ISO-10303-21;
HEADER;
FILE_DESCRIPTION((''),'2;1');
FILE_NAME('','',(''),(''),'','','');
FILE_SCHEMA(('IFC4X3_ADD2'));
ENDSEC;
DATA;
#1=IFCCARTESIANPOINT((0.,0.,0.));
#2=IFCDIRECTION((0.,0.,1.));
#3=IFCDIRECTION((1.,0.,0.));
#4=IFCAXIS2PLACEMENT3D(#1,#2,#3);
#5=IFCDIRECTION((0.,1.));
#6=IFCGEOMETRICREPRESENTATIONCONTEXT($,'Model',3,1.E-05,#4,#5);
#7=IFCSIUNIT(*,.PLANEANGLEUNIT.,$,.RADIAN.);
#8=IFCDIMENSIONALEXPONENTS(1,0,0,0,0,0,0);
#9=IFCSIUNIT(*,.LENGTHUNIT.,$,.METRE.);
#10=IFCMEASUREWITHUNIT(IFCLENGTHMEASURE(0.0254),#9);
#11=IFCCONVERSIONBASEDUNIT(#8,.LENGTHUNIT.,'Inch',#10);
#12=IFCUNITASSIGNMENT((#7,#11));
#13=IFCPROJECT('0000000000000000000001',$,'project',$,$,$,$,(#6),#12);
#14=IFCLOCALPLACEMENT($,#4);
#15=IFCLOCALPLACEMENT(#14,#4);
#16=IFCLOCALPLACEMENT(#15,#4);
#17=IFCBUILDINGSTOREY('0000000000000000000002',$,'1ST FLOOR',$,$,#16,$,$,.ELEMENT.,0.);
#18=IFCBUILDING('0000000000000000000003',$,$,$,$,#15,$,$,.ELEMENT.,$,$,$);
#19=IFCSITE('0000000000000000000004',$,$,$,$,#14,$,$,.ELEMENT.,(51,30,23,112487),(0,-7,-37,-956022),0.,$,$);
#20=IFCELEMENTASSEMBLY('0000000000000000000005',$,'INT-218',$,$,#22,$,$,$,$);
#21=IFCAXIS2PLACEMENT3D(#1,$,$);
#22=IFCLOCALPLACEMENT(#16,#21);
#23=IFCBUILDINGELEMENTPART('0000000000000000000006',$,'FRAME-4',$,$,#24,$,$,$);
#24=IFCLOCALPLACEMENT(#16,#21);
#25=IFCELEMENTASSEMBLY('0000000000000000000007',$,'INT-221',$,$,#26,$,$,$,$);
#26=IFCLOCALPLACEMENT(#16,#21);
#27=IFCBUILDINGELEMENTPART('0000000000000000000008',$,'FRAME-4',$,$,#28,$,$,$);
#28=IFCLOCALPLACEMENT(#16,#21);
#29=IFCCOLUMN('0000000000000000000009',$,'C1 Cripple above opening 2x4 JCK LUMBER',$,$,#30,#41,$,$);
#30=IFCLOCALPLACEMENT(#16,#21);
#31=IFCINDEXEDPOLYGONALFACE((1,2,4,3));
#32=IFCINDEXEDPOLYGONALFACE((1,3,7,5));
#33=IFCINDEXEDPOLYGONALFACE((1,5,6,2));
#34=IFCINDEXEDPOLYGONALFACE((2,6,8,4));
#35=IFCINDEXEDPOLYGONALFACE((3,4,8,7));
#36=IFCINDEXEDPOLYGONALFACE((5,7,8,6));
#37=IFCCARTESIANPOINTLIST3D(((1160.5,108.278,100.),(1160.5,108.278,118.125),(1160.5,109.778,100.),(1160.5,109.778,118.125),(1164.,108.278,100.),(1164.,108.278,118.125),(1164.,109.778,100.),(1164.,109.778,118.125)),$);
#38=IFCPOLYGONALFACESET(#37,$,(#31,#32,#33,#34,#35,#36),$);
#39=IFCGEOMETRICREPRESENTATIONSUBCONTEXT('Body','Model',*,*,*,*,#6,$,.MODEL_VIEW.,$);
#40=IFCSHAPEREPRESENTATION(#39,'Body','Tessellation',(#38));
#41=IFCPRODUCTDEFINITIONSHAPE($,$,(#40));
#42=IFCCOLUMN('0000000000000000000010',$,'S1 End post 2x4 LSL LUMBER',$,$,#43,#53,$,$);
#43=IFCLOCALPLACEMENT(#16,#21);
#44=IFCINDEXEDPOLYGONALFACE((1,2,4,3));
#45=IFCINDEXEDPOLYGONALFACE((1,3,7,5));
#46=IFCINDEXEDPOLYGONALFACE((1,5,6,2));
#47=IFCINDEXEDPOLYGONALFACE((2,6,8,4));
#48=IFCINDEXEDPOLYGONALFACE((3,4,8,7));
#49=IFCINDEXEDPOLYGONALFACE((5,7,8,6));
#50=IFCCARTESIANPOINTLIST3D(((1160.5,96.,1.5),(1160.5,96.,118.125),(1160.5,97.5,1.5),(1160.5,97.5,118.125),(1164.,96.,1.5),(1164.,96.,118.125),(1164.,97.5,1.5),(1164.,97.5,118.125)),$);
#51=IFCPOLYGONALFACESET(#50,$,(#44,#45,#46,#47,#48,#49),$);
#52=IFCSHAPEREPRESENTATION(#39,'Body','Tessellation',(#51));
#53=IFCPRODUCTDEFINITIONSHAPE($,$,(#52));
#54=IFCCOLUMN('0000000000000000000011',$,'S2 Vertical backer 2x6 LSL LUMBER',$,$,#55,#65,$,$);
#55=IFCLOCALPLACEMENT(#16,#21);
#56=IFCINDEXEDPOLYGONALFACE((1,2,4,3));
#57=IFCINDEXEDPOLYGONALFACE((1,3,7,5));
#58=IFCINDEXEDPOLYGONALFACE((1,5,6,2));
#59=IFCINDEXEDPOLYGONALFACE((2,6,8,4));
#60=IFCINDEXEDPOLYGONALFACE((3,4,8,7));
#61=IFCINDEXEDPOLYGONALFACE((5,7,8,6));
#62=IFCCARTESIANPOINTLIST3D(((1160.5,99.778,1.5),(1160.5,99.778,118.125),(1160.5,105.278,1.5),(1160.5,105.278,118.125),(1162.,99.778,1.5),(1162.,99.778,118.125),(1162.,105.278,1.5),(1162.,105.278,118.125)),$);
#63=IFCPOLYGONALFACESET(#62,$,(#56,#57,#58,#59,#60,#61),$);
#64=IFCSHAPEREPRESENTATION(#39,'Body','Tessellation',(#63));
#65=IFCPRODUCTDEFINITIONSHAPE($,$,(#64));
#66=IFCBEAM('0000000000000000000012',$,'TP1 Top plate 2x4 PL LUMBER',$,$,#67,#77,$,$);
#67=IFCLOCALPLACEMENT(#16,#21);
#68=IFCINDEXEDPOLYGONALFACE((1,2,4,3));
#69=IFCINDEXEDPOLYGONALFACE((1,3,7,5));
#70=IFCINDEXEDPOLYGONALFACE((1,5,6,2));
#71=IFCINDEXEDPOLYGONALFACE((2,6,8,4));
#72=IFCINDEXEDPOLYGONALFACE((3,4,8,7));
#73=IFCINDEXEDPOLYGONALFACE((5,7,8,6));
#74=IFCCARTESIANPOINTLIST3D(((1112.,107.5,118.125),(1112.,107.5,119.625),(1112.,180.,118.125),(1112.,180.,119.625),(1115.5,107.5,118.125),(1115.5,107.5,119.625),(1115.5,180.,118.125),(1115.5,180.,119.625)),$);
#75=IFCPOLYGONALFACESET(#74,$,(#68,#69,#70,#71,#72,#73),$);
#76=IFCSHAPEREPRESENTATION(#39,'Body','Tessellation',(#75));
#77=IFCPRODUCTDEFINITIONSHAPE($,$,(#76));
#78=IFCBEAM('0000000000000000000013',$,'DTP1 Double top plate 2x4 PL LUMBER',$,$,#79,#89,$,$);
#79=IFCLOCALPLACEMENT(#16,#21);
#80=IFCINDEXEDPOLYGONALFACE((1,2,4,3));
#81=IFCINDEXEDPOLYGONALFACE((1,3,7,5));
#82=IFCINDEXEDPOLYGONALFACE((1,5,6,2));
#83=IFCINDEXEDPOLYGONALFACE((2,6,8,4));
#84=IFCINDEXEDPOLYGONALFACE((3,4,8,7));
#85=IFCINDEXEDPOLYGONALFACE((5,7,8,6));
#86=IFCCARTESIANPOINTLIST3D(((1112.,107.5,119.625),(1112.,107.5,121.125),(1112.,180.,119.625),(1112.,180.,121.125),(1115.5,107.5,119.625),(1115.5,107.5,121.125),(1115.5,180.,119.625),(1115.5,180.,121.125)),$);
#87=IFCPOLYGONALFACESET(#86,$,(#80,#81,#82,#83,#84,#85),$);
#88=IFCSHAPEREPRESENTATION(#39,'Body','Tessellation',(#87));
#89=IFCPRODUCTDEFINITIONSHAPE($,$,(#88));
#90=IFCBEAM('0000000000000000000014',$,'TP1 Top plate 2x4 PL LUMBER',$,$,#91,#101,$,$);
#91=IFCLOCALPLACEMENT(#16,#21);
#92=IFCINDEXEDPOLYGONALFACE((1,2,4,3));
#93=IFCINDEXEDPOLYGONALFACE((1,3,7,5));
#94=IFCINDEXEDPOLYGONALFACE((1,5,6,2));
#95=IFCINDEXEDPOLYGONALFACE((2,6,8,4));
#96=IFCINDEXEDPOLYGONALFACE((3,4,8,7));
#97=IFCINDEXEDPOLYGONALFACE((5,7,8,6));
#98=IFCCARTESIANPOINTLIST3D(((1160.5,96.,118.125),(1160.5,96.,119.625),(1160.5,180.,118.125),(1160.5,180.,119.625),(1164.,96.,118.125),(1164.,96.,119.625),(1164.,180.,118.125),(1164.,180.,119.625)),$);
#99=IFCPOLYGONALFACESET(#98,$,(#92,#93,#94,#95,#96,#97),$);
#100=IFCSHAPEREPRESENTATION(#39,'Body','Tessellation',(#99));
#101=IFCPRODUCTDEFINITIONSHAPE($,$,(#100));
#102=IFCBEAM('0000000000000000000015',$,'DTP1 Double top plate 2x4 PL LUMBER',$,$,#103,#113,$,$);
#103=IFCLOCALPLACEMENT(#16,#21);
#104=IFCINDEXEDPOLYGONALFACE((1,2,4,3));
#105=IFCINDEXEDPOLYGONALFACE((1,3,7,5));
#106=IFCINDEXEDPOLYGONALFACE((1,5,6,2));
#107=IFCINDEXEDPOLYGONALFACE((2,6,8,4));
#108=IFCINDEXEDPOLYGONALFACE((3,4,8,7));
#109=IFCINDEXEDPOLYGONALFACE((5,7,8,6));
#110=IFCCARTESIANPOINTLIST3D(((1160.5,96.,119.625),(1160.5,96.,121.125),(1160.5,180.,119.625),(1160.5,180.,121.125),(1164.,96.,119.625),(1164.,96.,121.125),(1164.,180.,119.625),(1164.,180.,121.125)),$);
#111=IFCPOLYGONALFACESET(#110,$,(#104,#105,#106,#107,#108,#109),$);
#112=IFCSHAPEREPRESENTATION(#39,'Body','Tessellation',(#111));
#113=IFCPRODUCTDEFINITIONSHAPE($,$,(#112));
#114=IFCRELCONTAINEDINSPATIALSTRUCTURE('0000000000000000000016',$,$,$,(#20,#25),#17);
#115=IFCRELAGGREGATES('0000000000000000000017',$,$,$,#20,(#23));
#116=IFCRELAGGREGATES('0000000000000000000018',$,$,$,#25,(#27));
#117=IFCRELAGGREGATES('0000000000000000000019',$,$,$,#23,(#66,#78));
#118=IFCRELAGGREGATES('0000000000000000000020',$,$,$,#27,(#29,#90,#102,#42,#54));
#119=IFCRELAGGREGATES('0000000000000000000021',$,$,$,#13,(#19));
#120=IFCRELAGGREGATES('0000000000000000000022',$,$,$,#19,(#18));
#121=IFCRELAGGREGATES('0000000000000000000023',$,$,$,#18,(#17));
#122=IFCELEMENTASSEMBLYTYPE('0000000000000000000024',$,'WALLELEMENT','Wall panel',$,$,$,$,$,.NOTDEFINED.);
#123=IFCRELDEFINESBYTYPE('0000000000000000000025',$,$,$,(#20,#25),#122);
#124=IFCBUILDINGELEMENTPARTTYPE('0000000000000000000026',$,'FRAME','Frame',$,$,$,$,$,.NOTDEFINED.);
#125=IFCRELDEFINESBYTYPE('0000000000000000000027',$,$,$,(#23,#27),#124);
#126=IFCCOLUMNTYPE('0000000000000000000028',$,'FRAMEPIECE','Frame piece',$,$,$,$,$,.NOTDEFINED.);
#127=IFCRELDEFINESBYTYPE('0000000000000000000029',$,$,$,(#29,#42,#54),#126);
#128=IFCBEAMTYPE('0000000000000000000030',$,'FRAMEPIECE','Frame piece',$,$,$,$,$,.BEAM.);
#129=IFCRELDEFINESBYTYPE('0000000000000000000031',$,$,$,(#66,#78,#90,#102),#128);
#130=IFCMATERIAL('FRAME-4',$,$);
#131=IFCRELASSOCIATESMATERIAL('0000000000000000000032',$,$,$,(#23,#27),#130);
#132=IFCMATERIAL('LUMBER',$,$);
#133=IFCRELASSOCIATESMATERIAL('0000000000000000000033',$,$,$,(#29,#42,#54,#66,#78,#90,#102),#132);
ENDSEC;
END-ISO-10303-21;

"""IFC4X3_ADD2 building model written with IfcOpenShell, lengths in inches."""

from ifc_helpers import new_model, entity, si_unit, converted_unit, direction, frame, origin_with_axes, origin_2d_with_axis, place, context, subcontext, project, spatial, rectangle, extrude, material, type_object, element, aggregate, save


model = new_model("IFC4X3_ADD2")

# Units and contexts
model_context = context("Model", 3, precision=1e-05, world=origin_with_axes(), true_north=direction((0.0, 1.0)))
body_context = subcontext(model_context, "Body", "Model", "MODEL_VIEW")
ifc_project = project(units=[si_unit("PLANEANGLEUNIT", "RADIAN"), converted_unit("LENGTHUNIT", "Inch", entity("IfcLengthMeasure", 0.0254), si_unit("LENGTHUNIT", "METRE"), dimensions=[1, 0, 0, 0, 0, 0, 0])], contexts=[model_context])

# Site, building, storey
site_placement = place(None, origin_with_axes())
site = spatial("IfcSite", under=ifc_project, at=site_placement, CompositionType="ELEMENT", RefLatitude=(51, 30, 23, 112487), RefLongitude=(0, -7, -37, -956022), RefElevation=0.0)
building_placement = place(site_placement, origin_with_axes())
building = spatial("IfcBuilding", under=site, at=building_placement, CompositionType="ELEMENT")
storey_placement = place(building_placement, origin_with_axes())
storey = spatial("IfcBuildingStorey", under=building, at=storey_placement, Name="1ST FLOOR", CompositionType="ELEMENT", Elevation=0.0)

# Element assemblies, building element parts, columns
element_assembly_type = type_object("IfcElementAssemblyType", Name="WALLELEMENT", Description="Wall panel", PredefinedType="NOTDEFINED")
building_element_part_type = type_object("IfcBuildingElementPartType", Name="FRAME", Description="Frame", PredefinedType="NOTDEFINED")
ifc_material_1 = material(Name="LUMBER")
column_type = type_object("IfcColumnType", Name="FRAMEPIECE", Description="Frame piece", PredefinedType="NOTDEFINED")
assembly_1_placement = place(storey_placement, origin_with_axes())
assembly_1 = element("IfcElementAssembly", 1, at=assembly_1_placement, inside=storey, type_object=element_assembly_type, Name="INT-218")
ifc_material_2 = material(Name="FRAME-4")
building_element_part_1_placement = place(storey_placement, origin_with_axes())
building_element_part_1 = element("IfcBuildingElementPart", 2, at=building_element_part_1_placement, type_object=building_element_part_type, material=ifc_material_2, Name="FRAME-4")
aggregate(assembly_1, [building_element_part_1])
assembly_2_placement = place(storey_placement, origin_with_axes())
assembly_2 = element("IfcElementAssembly", 3, at=assembly_2_placement, inside=storey, type_object=element_assembly_type, Name="INT-221")
building_element_part_2_placement = place(storey_placement, origin_with_axes())
building_element_part_2 = element("IfcBuildingElementPart", 4, at=building_element_part_2_placement, type_object=building_element_part_type, material=ifc_material_2, Name="FRAME-4")
aggregate(assembly_2, [building_element_part_2])
column_1_placement = place(storey_placement, frame((1162.25, 109.028, 118.125), z_axis=(0.0, 0.0, -1.0), x_axis=(0.0, 1.0, 0.0)))
column_1 = element("IfcColumn", 5, at=column_1_placement, type_object=column_type, material=ifc_material_1, Name="C1 Cripple above opening 2x4 JCK LUMBER", context=body_context, shape_type="SweptSolid", body=[
    extrude(rectangle(XDim=1.5, YDim=3.5, at=origin_2d_with_axis()), origin_with_axes(), (0.0, 0.0, 1.0), 18.125),
])
column_2_placement = place(storey_placement, frame((1162.25, 96.75, 118.125), z_axis=(0.0, 0.0, -1.0), x_axis=(0.0, 1.0, 0.0)))
column_2 = element("IfcColumn", 6, at=column_2_placement, type_object=column_type, material=ifc_material_1, Name="S1 End post 2x4 LSL LUMBER", context=body_context, shape_type="SweptSolid", body=[
    extrude(rectangle(XDim=1.5, YDim=3.5, at=origin_2d_with_axis()), origin_with_axes(), (0.0, 0.0, 1.0), 116.625),
])
column_3_placement = place(storey_placement, frame((1161.25, 102.528, 118.125), z_axis=(0.0, 0.0, -1.0), x_axis=(1.0, 0.0, 0.0)))
column_3 = element("IfcColumn", 7, at=column_3_placement, type_object=column_type, material=ifc_material_1, Name="S2 Vertical backer 2x6 LSL LUMBER", context=body_context, shape_type="SweptSolid", body=[
    extrude(rectangle(XDim=1.5, YDim=5.5, at=origin_2d_with_axis()), origin_with_axes(), (0.0, 0.0, 1.0), 116.625),
])

# Beams
beam_type = type_object("IfcBeamType", Name="FRAMEPIECE", Description="Frame piece", PredefinedType="BEAM")
beam_1_placement = place(storey_placement, frame((1113.75, 107.5, 118.875), z_axis=(0.0, 1.0, 0.0), x_axis=(0.0, 0.0, -1.0)))
beam_1 = element("IfcBeam", 8, at=beam_1_placement, type_object=beam_type, material=ifc_material_1, Name="TP1 Top plate 2x4 PL LUMBER", context=body_context, shape_type="SweptSolid", body=[
    extrude(rectangle(XDim=1.5, YDim=3.5, at=origin_2d_with_axis()), origin_with_axes(), (0.0, 0.0, 1.0), 72.5),
])
beam_2_placement = place(storey_placement, frame((1113.75, 107.5, 120.375), z_axis=(0.0, 1.0, 0.0), x_axis=(0.0, 0.0, -1.0)))
beam_2 = element("IfcBeam", 9, at=beam_2_placement, type_object=beam_type, material=ifc_material_1, Name="DTP1 Double top plate 2x4 PL LUMBER", context=body_context, shape_type="SweptSolid", body=[
    extrude(rectangle(XDim=1.5, YDim=3.5, at=origin_2d_with_axis()), origin_with_axes(), (0.0, 0.0, 1.0), 72.5),
])
aggregate(building_element_part_1, [beam_1, beam_2])
beam_3_placement = place(storey_placement, frame((1162.25, 180.0, 118.875), z_axis=(0.0, -1.0, 0.0), x_axis=(0.0, 0.0, -1.0)))
beam_3 = element("IfcBeam", 10, at=beam_3_placement, type_object=beam_type, material=ifc_material_1, Name="TP1 Top plate 2x4 PL LUMBER", context=body_context, shape_type="SweptSolid", body=[
    extrude(rectangle(XDim=1.5, YDim=3.5, at=origin_2d_with_axis()), origin_with_axes(), (0.0, 0.0, 1.0), 84.0),
])
beam_4_placement = place(storey_placement, frame((1162.25, 180.0, 120.375), z_axis=(0.0, -1.0, 0.0), x_axis=(0.0, 0.0, -1.0)))
beam_4 = element("IfcBeam", 11, at=beam_4_placement, type_object=beam_type, material=ifc_material_1, Name="DTP1 Double top plate 2x4 PL LUMBER", context=body_context, shape_type="SweptSolid", body=[
    extrude(rectangle(XDim=1.5, YDim=3.5, at=origin_2d_with_axis()), origin_with_axes(), (0.0, 0.0, 1.0), 84.0),
])
aggregate(building_element_part_2, [column_1, beam_3, beam_4, column_2, column_3])

save(model, "model.ifc")
